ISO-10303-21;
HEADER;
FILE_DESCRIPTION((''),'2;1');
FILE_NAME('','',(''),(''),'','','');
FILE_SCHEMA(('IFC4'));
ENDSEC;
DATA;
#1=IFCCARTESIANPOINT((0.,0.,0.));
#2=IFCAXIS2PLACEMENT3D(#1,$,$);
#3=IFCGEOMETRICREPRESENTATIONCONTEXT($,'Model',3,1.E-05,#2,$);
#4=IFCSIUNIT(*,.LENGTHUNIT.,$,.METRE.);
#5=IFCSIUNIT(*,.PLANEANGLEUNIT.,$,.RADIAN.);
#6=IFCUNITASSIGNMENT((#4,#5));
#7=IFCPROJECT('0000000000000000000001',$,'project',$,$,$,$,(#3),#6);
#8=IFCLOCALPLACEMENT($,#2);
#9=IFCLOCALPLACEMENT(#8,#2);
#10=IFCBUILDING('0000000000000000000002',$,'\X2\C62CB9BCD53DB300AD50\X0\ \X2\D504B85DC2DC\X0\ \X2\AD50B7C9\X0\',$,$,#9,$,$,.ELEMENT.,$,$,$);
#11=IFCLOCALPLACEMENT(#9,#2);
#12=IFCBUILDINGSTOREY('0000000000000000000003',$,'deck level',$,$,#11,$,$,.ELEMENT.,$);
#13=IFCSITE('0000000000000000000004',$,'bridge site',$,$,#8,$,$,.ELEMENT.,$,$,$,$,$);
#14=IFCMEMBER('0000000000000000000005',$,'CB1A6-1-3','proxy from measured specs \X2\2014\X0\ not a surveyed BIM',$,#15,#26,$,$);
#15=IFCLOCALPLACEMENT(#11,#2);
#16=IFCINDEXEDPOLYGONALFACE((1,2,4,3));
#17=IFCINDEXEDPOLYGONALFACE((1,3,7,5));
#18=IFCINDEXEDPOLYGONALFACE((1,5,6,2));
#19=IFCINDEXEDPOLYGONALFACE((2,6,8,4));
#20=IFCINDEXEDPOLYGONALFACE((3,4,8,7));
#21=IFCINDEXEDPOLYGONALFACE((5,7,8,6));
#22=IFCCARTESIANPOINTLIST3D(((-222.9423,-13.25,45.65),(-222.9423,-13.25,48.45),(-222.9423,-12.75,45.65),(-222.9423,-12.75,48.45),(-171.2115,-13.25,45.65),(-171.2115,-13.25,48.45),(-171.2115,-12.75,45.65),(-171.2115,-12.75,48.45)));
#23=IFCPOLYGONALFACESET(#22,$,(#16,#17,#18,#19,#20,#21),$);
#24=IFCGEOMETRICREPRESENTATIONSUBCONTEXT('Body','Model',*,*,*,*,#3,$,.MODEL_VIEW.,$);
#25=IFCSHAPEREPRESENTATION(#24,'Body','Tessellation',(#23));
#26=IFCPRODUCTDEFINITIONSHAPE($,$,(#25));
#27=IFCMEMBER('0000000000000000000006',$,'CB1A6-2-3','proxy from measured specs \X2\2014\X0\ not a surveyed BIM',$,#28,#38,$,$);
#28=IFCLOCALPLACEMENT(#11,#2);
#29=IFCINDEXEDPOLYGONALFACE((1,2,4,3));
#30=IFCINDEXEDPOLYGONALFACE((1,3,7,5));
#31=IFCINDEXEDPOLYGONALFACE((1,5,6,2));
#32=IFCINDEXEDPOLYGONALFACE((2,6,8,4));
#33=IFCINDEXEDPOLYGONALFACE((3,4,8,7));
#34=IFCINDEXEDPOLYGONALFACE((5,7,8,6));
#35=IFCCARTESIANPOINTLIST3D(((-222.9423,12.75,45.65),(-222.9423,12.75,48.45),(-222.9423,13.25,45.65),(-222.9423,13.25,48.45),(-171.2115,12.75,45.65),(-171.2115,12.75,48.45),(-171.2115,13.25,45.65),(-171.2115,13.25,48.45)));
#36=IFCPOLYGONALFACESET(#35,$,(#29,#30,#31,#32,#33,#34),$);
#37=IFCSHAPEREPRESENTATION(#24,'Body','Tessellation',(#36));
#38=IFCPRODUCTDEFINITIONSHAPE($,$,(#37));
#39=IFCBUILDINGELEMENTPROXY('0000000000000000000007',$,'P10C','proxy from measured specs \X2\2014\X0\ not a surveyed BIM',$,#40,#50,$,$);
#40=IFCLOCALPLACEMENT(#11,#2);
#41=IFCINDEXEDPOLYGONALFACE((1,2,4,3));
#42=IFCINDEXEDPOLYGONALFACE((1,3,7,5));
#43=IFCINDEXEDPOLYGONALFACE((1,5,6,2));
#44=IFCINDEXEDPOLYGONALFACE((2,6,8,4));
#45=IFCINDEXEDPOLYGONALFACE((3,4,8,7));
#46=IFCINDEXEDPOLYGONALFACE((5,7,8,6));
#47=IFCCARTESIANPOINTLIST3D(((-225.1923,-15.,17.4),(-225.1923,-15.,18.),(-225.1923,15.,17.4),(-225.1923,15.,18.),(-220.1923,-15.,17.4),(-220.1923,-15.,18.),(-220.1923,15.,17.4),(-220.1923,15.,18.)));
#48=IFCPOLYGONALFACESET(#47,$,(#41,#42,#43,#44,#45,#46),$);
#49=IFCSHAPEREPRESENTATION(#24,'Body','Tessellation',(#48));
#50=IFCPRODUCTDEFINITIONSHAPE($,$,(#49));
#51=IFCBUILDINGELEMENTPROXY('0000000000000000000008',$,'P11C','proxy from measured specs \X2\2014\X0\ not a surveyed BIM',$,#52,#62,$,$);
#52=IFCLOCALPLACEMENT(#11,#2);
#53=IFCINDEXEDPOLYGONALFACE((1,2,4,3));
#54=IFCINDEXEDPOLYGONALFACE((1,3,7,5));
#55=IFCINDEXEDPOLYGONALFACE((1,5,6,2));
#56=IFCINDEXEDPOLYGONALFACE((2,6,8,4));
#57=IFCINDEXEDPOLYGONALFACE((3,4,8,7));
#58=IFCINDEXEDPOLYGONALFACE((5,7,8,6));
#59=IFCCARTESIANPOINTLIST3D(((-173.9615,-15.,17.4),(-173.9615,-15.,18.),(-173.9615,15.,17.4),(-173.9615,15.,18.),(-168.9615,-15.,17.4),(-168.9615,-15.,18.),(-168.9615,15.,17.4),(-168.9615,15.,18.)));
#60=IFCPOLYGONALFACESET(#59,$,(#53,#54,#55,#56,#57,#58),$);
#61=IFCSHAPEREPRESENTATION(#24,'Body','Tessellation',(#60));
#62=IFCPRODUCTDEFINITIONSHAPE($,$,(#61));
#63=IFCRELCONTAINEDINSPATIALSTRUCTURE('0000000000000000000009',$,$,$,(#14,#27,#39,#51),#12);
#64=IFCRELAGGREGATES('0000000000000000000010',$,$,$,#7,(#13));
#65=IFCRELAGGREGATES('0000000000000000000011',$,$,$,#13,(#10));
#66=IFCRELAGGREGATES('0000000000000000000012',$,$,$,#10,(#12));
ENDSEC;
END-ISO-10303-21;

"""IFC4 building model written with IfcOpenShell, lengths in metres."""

from ifc_helpers import new_model, si_unit, frame, origin, origin_2d, place, context, subcontext, project, spatial, rectangle, extrude, element, save


model = new_model("IFC4")

# Units and contexts
model_context = context("Model", 3, precision=1e-05, world=origin())
body_context = subcontext(model_context, "Body", "Model", "MODEL_VIEW")
ifc_project = project(units=[si_unit("LENGTHUNIT", "METRE"), si_unit("PLANEANGLEUNIT", "RADIAN")], contexts=[model_context])

# Site, building, storey
site_placement = place(None, origin())
site = spatial("IfcSite", under=ifc_project, at=site_placement, Name="bridge site", CompositionType="ELEMENT")
building_placement = place(site_placement, origin())
building = spatial("IfcBuilding", under=site, at=building_placement, Name="올림픽대교 프록시 교량", CompositionType="ELEMENT")
storey_placement = place(building_placement, origin())
storey = spatial("IfcBuildingStorey", under=building, at=storey_placement, Name="deck level", CompositionType="ELEMENT")

# Members
for number, where, name in (
    (1, (-197.0769, -13.0, 45.65), "CB1A6-1-3"),
    (2, (-197.0769, 13.0, 45.65), "CB1A6-2-3"),
):
    element("IfcMember", number, at=place(storey_placement, frame(where)), inside=storey, Name=name, Description="proxy from measured specs — not a surveyed BIM", context=body_context, shape_type="SweptSolid", body=[
        extrude(rectangle(XDim=51.7308, YDim=0.5, at=origin_2d()), origin(), (0.0, 0.0, 1.0), 2.8),
    ])

# Building element proxies
for number, where, name in (
    (3, (-222.6923, 0.0, 17.4), "P10C"),
    (4, (-171.4615, 0.0, 17.4), "P11C"),
):
    element("IfcBuildingElementProxy", number, at=place(storey_placement, frame(where)), inside=storey, Name=name, Description="proxy from measured specs — not a surveyed BIM", context=body_context, shape_type="SweptSolid", body=[
        extrude(rectangle(XDim=5.0, YDim=30.0, at=origin_2d()), origin(), (0.0, 0.0, 1.0), 0.6),
    ])

save(model, "model.ifc")
